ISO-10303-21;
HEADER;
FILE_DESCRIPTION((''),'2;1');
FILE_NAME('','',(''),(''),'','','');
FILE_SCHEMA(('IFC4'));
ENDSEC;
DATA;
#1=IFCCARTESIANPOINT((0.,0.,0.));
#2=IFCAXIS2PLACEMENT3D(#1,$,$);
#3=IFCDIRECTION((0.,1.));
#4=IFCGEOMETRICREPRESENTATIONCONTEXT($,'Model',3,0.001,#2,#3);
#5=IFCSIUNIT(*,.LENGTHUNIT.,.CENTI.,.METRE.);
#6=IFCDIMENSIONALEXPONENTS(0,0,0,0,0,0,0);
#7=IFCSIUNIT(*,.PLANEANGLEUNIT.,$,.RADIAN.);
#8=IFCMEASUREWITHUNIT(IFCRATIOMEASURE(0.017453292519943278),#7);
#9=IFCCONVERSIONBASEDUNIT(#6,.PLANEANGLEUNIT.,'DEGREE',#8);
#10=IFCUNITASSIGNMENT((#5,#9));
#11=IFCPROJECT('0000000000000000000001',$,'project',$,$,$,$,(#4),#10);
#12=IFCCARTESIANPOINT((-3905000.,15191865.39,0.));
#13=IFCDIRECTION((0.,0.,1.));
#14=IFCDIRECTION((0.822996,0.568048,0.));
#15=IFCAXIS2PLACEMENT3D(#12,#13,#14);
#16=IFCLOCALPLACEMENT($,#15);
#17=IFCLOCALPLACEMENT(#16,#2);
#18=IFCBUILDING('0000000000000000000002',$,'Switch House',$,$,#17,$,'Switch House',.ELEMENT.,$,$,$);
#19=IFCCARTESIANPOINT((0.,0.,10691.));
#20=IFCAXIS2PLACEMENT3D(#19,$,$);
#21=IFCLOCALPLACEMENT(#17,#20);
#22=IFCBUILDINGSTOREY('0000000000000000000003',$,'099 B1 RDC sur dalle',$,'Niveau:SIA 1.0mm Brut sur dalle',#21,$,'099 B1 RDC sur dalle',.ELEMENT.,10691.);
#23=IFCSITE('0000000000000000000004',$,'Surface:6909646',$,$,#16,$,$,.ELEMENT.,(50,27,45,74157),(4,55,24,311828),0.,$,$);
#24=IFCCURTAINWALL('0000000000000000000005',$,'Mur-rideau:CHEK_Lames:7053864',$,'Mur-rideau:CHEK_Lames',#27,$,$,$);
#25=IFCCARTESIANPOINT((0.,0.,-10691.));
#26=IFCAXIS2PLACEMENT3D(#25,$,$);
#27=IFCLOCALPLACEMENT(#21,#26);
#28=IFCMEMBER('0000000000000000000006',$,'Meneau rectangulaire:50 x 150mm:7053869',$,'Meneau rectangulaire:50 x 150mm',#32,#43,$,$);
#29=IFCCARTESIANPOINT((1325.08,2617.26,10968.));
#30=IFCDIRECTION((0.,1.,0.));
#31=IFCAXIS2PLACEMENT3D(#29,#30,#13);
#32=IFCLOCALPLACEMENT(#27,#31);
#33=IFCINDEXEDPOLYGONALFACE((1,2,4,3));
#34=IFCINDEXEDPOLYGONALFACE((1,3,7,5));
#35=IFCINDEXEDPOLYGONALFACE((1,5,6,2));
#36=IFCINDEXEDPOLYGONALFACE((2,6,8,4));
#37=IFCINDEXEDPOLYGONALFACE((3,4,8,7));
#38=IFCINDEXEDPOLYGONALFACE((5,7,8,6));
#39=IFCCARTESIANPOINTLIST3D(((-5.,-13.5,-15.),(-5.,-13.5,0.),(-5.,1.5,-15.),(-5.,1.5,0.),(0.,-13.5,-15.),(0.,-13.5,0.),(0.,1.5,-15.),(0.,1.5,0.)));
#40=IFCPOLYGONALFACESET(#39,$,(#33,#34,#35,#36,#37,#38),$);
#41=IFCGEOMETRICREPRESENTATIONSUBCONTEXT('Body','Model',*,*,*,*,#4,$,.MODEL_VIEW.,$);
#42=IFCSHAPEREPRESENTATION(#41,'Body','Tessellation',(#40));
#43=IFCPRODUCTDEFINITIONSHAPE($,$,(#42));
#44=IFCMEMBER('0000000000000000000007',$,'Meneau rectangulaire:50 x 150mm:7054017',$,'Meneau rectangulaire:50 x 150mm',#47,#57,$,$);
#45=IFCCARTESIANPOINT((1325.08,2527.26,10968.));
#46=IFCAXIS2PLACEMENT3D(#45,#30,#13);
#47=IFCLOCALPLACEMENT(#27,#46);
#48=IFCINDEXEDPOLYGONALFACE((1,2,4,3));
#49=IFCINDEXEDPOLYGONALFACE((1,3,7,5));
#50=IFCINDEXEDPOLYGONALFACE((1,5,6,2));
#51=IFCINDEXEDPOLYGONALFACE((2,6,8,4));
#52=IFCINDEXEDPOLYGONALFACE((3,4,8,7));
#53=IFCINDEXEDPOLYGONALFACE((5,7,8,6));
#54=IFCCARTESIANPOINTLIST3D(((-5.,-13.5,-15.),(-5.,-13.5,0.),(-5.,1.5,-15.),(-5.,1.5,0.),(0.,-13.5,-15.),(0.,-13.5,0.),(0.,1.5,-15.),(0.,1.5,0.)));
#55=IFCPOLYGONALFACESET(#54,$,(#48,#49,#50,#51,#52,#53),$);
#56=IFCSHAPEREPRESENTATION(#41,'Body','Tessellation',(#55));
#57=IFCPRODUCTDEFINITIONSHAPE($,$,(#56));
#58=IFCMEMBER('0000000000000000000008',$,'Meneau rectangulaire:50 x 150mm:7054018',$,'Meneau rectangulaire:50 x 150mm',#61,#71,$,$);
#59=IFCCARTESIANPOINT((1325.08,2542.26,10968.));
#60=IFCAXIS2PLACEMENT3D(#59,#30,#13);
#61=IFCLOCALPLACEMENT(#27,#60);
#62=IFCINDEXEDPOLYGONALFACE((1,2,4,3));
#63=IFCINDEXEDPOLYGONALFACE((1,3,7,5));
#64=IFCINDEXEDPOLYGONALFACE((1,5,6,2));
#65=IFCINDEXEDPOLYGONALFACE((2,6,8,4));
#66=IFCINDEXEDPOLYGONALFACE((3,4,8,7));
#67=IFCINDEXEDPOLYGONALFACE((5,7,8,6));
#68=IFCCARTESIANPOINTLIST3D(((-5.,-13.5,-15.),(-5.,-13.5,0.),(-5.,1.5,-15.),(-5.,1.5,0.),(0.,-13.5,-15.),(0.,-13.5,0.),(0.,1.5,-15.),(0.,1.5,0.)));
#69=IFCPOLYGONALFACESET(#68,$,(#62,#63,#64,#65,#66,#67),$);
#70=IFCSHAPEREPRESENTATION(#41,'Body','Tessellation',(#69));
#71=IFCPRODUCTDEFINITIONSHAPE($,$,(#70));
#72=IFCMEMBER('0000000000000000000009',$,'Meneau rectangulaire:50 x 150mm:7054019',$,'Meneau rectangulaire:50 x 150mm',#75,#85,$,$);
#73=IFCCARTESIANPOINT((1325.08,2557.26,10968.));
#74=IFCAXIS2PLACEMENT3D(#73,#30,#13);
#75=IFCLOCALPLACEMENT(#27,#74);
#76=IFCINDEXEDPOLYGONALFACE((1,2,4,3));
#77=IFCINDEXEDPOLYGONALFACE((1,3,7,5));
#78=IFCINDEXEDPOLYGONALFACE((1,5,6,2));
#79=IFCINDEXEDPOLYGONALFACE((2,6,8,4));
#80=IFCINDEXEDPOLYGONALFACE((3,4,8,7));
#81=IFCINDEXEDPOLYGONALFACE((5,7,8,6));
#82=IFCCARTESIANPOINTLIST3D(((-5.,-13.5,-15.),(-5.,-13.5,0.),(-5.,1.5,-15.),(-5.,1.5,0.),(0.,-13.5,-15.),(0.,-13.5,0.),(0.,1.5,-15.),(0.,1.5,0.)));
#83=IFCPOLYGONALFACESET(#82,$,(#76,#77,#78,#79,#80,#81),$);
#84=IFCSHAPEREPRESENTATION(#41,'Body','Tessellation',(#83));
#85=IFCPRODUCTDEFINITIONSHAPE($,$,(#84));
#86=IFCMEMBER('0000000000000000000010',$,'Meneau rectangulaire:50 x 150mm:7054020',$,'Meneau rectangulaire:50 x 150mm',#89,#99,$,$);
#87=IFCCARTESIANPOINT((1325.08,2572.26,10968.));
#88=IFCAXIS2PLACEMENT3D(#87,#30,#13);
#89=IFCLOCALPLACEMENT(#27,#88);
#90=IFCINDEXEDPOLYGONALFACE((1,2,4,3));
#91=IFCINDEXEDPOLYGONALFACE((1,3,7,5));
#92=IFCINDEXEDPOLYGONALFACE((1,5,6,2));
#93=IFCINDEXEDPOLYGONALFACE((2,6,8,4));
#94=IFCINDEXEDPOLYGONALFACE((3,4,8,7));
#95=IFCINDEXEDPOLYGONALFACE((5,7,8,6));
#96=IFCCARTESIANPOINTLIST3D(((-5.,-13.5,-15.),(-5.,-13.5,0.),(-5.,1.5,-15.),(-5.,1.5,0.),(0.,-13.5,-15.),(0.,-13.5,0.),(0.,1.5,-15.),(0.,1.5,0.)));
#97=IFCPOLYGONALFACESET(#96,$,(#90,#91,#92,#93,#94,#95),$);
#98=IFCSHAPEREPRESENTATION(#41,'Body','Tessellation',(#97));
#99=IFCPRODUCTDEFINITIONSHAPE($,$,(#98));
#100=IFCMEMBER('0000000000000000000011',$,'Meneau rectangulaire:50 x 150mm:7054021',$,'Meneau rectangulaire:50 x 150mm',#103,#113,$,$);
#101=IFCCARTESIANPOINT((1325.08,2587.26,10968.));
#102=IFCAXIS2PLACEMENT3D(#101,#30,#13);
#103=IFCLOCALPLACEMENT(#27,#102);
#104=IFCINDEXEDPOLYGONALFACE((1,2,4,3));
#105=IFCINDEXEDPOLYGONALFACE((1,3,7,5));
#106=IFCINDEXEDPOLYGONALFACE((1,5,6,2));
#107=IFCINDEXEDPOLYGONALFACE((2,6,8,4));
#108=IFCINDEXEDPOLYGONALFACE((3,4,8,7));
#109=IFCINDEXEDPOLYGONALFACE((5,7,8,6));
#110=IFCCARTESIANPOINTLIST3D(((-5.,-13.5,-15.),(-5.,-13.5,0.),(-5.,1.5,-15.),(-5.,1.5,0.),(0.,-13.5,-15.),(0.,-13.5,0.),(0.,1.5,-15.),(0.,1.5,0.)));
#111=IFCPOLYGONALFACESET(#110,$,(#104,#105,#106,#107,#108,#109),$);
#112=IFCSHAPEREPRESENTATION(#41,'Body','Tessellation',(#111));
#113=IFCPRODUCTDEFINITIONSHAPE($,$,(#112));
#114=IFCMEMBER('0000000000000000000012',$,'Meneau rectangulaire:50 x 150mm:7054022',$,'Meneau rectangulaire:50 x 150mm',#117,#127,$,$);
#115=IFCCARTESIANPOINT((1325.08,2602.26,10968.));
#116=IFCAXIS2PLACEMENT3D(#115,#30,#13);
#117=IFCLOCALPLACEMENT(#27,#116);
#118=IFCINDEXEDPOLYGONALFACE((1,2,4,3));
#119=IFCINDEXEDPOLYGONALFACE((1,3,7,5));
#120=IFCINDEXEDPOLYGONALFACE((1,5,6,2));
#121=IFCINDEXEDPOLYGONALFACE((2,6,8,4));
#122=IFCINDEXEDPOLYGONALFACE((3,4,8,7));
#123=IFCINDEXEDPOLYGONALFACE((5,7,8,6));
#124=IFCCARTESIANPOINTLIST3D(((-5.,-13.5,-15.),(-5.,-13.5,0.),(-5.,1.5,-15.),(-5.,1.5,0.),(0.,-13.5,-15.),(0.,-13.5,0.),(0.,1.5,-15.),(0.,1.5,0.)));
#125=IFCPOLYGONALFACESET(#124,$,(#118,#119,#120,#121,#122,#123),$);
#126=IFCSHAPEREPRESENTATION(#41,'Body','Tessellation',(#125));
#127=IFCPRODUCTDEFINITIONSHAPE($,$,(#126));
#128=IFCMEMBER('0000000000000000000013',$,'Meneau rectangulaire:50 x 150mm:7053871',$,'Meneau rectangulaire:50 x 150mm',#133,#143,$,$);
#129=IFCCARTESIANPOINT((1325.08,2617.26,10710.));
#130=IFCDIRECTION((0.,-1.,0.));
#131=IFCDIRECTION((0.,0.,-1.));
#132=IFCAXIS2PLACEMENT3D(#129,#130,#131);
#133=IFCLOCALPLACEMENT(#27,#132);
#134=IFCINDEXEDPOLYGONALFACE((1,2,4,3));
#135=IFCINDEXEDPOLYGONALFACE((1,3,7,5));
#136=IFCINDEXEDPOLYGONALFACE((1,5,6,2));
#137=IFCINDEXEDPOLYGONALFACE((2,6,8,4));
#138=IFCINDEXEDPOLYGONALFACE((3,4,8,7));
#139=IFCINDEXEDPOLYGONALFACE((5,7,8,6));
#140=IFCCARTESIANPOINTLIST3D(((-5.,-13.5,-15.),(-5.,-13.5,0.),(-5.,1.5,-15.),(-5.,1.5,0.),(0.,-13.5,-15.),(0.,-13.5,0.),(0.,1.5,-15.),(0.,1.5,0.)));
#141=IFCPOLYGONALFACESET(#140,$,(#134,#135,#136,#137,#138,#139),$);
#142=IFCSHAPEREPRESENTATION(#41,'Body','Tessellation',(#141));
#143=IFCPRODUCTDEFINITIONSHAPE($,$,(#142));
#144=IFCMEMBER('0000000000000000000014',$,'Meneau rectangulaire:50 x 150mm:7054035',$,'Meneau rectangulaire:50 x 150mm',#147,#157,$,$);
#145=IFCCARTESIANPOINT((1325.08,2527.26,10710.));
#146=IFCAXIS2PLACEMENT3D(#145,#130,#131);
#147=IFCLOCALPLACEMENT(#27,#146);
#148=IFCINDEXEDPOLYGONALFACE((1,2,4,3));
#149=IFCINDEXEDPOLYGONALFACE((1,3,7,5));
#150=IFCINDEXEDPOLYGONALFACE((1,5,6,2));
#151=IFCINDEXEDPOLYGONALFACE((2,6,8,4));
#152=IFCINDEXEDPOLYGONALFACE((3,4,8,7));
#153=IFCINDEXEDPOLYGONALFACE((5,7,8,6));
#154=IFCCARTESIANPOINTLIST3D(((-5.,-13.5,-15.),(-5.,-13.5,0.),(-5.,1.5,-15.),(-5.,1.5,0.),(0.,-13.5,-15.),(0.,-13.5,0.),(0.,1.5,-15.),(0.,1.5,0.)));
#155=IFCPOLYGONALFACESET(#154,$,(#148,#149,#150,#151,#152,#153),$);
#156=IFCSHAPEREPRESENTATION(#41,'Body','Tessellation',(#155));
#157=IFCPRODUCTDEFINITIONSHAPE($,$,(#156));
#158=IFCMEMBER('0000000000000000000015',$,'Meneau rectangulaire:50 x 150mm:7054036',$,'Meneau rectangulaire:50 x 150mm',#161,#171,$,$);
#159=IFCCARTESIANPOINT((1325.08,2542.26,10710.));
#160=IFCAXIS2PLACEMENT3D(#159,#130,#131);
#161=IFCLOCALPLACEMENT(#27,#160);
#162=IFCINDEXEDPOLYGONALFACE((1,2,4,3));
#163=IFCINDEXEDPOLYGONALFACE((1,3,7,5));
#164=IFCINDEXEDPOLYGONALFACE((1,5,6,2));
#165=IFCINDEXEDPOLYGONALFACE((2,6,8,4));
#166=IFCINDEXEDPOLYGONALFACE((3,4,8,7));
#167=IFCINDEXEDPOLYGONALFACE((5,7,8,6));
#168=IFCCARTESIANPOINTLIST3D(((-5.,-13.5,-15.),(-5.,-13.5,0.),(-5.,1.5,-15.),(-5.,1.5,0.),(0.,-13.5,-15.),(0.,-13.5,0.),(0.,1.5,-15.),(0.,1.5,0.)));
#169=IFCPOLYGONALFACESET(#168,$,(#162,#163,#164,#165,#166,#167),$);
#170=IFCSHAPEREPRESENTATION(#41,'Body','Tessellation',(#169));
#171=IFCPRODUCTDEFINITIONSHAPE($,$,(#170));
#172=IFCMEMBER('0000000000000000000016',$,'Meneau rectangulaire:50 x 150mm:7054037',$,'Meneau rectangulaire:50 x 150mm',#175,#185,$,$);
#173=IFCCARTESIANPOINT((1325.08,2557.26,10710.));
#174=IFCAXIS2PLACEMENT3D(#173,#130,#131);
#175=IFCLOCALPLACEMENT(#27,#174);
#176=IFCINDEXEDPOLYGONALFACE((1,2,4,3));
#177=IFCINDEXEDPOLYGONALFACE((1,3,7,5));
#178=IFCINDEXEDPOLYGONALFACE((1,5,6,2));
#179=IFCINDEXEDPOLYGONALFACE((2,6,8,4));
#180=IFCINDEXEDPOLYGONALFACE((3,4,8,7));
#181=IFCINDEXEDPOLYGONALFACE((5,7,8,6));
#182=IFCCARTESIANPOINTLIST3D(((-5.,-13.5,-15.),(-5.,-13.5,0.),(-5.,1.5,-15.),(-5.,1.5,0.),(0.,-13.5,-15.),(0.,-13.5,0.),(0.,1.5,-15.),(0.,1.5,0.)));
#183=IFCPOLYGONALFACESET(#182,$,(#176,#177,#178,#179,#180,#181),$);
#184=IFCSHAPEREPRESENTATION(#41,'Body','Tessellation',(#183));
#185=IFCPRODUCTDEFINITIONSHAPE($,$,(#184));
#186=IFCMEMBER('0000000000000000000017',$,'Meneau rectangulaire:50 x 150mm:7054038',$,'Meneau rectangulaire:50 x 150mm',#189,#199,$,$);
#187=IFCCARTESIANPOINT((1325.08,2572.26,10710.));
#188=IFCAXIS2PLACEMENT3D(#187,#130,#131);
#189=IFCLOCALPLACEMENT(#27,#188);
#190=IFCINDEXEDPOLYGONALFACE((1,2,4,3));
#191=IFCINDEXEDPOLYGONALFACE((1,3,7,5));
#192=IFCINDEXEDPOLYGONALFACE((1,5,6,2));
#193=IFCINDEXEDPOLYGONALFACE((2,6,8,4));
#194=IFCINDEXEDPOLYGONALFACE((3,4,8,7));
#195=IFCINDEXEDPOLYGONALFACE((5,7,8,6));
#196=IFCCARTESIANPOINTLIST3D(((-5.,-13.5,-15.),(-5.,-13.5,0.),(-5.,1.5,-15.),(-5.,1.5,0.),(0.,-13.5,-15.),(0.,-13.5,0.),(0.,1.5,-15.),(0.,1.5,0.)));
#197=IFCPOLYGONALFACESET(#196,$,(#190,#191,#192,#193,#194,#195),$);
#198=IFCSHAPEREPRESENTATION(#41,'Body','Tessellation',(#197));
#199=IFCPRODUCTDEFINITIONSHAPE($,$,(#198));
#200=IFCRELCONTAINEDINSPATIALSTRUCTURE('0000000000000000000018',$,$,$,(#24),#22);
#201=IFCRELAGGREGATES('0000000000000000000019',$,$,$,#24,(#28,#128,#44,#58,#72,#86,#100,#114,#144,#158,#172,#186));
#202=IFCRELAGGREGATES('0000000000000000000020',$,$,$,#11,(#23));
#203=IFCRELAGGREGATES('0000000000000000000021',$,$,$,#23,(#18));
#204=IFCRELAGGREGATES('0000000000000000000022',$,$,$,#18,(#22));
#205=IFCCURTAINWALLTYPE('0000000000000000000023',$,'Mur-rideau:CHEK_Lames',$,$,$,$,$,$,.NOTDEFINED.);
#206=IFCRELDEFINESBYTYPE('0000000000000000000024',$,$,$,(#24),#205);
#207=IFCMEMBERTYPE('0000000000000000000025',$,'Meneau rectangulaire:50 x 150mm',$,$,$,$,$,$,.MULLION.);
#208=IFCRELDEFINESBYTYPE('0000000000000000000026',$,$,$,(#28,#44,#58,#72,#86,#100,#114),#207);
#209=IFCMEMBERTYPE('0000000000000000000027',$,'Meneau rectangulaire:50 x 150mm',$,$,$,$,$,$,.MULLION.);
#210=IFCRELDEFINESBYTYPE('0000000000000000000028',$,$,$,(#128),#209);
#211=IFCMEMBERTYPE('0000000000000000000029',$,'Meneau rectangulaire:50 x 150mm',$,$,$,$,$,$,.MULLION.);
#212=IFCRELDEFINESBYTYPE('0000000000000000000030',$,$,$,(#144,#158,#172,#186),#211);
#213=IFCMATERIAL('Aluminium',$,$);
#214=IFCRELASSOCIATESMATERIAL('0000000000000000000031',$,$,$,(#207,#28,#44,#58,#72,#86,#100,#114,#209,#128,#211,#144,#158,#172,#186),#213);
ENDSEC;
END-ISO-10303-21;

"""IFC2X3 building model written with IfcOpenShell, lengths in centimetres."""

from ifc_helpers import new_model, entity, si_unit, converted_unit, direction, frame, origin, origin_2d_with_axis, place, context, subcontext, project, spatial, rectangle, extrude, source, transform, mapped, material, type_object, type_shapes, element, aggregate, save


model = new_model("IFC2X3")

# Units and contexts
model_context = context("Model", 3, precision=0.001, world=origin(), true_north=direction((0.0, 1.0)))
body_context = subcontext(model_context, "Body", "Model", "MODEL_VIEW")
ifc_project = project(units=[si_unit("LENGTHUNIT", "METRE", prefix="CENTI"), converted_unit("PLANEANGLEUNIT", "DEGREE", entity("IfcRatioMeasure", 0.017453292519943278), si_unit("PLANEANGLEUNIT", "RADIAN"), dimensions=[0, 0, 0, 0, 0, 0, 0])], contexts=[model_context])

# Site, building, storey
site_placement = place(None, frame((-3905000.0, 15191865.39, 0.0), z_axis=(0.0, 0.0, 1.0), x_axis=(0.822996, 0.568048, 0.0)))
site = spatial("IfcSite", under=ifc_project, at=site_placement, Name="Surface:6909646", CompositionType="ELEMENT", RefLatitude=(50, 27, 45, 74157), RefLongitude=(4, 55, 24, 311828), RefElevation=0.0)
building_placement = place(site_placement, origin())
building = spatial("IfcBuilding", under=site, at=building_placement, Name="Switch House", LongName="Switch House", CompositionType="ELEMENT")
storey_placement = place(building_placement, frame((0.0, 0.0, 10691.0)))
storey = spatial("IfcBuildingStorey", under=building, at=storey_placement, Name="099 B1 RDC sur dalle", ObjectType="Niveau:SIA 1.0mm Brut sur dalle", LongName="099 B1 RDC sur dalle", CompositionType="ELEMENT", Elevation=10691.0)

# Curtain wall
curtain_wall_type_1 = type_object("IfcCurtainWallType", Name="Mur-rideau:CHEK_Lames", PredefinedType="NOTDEFINED")
curtain_wall_1_placement = place(storey_placement, frame((0.0, 0.0, -10691.0)))
curtain_wall_1 = element("IfcCurtainWall", 1, at=curtain_wall_1_placement, inside=storey, type_object=curtain_wall_type_1, Name="Mur-rideau:CHEK_Lames:7053864", ObjectType="Mur-rideau:CHEK_Lames")
ifc_material_1 = material(Name="Aluminium")

# Members
member_type_1 = type_object("IfcMemberType", Name="Meneau rectangulaire:50 x 150mm", PredefinedType="MULLION", material=ifc_material_1)
shared_shape_1 = source(origin(), body_context, "Body", "SweptSolid", [
    extrude(rectangle(XDim=15.0, YDim=5.0, at=origin_2d_with_axis()), frame((-2.5, -6.0, -15.0), z_axis=(0.0, 0.0, 1.0), x_axis=(0.0, -1.0, 0.0)), (0.0, 0.0, 1.0), 15.0),
])
type_shapes(member_type_1, [shared_shape_1])
member_1_placement = place(curtain_wall_1_placement, frame((1325.08, 2617.26, 10968.0), z_axis=(0.0, 1.0, 0.0), x_axis=(0.0, 0.0, 1.0)))
member_1 = element("IfcMember", 2, at=member_1_placement, type_object=member_type_1, material=ifc_material_1, Name="Meneau rectangulaire:50 x 150mm:7053869", ObjectType="Meneau rectangulaire:50 x 150mm", context=body_context, shape_type="MappedRepresentation", body=[
    mapped(shared_shape_1, transform((0.0, 0.0, 0.0), scale=1.0)),
])
member_2_placement = place(curtain_wall_1_placement, frame((1325.08, 2527.26, 10968.0), z_axis=(0.0, 1.0, 0.0), x_axis=(0.0, 0.0, 1.0)))
member_2 = element("IfcMember", 3, at=member_2_placement, type_object=member_type_1, material=ifc_material_1, Name="Meneau rectangulaire:50 x 150mm:7054017", ObjectType="Meneau rectangulaire:50 x 150mm", context=body_context, shape_type="MappedRepresentation", body=[
    mapped(shared_shape_1, transform((0.0, 0.0, 0.0), scale=1.0)),
])
member_3_placement = place(curtain_wall_1_placement, frame((1325.08, 2542.26, 10968.0), z_axis=(0.0, 1.0, 0.0), x_axis=(0.0, 0.0, 1.0)))
member_3 = element("IfcMember", 4, at=member_3_placement, type_object=member_type_1, material=ifc_material_1, Name="Meneau rectangulaire:50 x 150mm:7054018", ObjectType="Meneau rectangulaire:50 x 150mm", context=body_context, shape_type="MappedRepresentation", body=[
    mapped(shared_shape_1, transform((0.0, 0.0, 0.0), scale=1.0)),
])
member_4_placement = place(curtain_wall_1_placement, frame((1325.08, 2557.26, 10968.0), z_axis=(0.0, 1.0, 0.0), x_axis=(0.0, 0.0, 1.0)))
member_4 = element("IfcMember", 5, at=member_4_placement, type_object=member_type_1, material=ifc_material_1, Name="Meneau rectangulaire:50 x 150mm:7054019", ObjectType="Meneau rectangulaire:50 x 150mm", context=body_context, shape_type="MappedRepresentation", body=[
    mapped(shared_shape_1, transform((0.0, 0.0, 0.0), scale=1.0)),
])
member_5_placement = place(curtain_wall_1_placement, frame((1325.08, 2572.26, 10968.0), z_axis=(0.0, 1.0, 0.0), x_axis=(0.0, 0.0, 1.0)))
member_5 = element("IfcMember", 6, at=member_5_placement, type_object=member_type_1, material=ifc_material_1, Name="Meneau rectangulaire:50 x 150mm:7054020", ObjectType="Meneau rectangulaire:50 x 150mm", context=body_context, shape_type="MappedRepresentation", body=[
    mapped(shared_shape_1, transform((0.0, 0.0, 0.0), scale=1.0)),
])
member_6_placement = place(curtain_wall_1_placement, frame((1325.08, 2587.26, 10968.0), z_axis=(0.0, 1.0, 0.0), x_axis=(0.0, 0.0, 1.0)))
member_6 = element("IfcMember", 7, at=member_6_placement, type_object=member_type_1, material=ifc_material_1, Name="Meneau rectangulaire:50 x 150mm:7054021", ObjectType="Meneau rectangulaire:50 x 150mm", context=body_context, shape_type="MappedRepresentation", body=[
    mapped(shared_shape_1, transform((0.0, 0.0, 0.0), scale=1.0)),
])
member_7_placement = place(curtain_wall_1_placement, frame((1325.08, 2602.26, 10968.0), z_axis=(0.0, 1.0, 0.0), x_axis=(0.0, 0.0, 1.0)))
member_7 = element("IfcMember", 8, at=member_7_placement, type_object=member_type_1, material=ifc_material_1, Name="Meneau rectangulaire:50 x 150mm:7054022", ObjectType="Meneau rectangulaire:50 x 150mm", context=body_context, shape_type="MappedRepresentation", body=[
    mapped(shared_shape_1, transform((0.0, 0.0, 0.0), scale=1.0)),
])
member_type_2 = type_object("IfcMemberType", Name="Meneau rectangulaire:50 x 150mm", PredefinedType="MULLION", material=ifc_material_1)
shared_shape_2 = source(origin(), body_context, "Body", "SweptSolid", [
    extrude(rectangle(XDim=15.0, YDim=5.0, at=origin_2d_with_axis()), frame((-2.5, -6.0, -15.0), z_axis=(0.0, 0.0, 1.0), x_axis=(0.0, -1.0, 0.0)), (0.0, 0.0, 1.0), 15.0),
])
type_shapes(member_type_2, [shared_shape_2])
member_8_placement = place(curtain_wall_1_placement, frame((1325.08, 2617.26, 10710.0), z_axis=(0.0, -1.0, 0.0), x_axis=(0.0, 0.0, -1.0)))
member_8 = element("IfcMember", 9, at=member_8_placement, type_object=member_type_2, material=ifc_material_1, Name="Meneau rectangulaire:50 x 150mm:7053871", ObjectType="Meneau rectangulaire:50 x 150mm", context=body_context, shape_type="MappedRepresentation", body=[
    mapped(shared_shape_2, transform((0.0, 0.0, 0.0), scale=1.0)),
])
member_type_3 = type_object("IfcMemberType", Name="Meneau rectangulaire:50 x 150mm", PredefinedType="MULLION", material=ifc_material_1)
shared_shape_3 = source(origin(), body_context, "Body", "SweptSolid", [
    extrude(rectangle(XDim=15.0, YDim=5.0, at=origin_2d_with_axis()), frame((-2.5, -6.0, -15.0), z_axis=(0.0, 0.0, 1.0), x_axis=(0.0, -1.0, 0.0)), (0.0, 0.0, 1.0), 15.0),
])
type_shapes(member_type_3, [shared_shape_3])
member_9_placement = place(curtain_wall_1_placement, frame((1325.08, 2527.26, 10710.0), z_axis=(0.0, -1.0, 0.0), x_axis=(0.0, 0.0, -1.0)))
member_9 = element("IfcMember", 10, at=member_9_placement, type_object=member_type_3, material=ifc_material_1, Name="Meneau rectangulaire:50 x 150mm:7054035", ObjectType="Meneau rectangulaire:50 x 150mm", context=body_context, shape_type="MappedRepresentation", body=[
    mapped(shared_shape_3, transform((0.0, 0.0, 0.0), scale=1.0)),
])
member_10_placement = place(curtain_wall_1_placement, frame((1325.08, 2542.26, 10710.0), z_axis=(0.0, -1.0, 0.0), x_axis=(0.0, 0.0, -1.0)))
member_10 = element("IfcMember", 11, at=member_10_placement, type_object=member_type_3, material=ifc_material_1, Name="Meneau rectangulaire:50 x 150mm:7054036", ObjectType="Meneau rectangulaire:50 x 150mm", context=body_context, shape_type="MappedRepresentation", body=[
    mapped(shared_shape_3, transform((0.0, 0.0, 0.0), scale=1.0)),
])
member_11_placement = place(curtain_wall_1_placement, frame((1325.08, 2557.26, 10710.0), z_axis=(0.0, -1.0, 0.0), x_axis=(0.0, 0.0, -1.0)))
member_11 = element("IfcMember", 12, at=member_11_placement, type_object=member_type_3, material=ifc_material_1, Name="Meneau rectangulaire:50 x 150mm:7054037", ObjectType="Meneau rectangulaire:50 x 150mm", context=body_context, shape_type="MappedRepresentation", body=[
    mapped(shared_shape_3, transform((0.0, 0.0, 0.0), scale=1.0)),
])
member_12_placement = place(curtain_wall_1_placement, frame((1325.08, 2572.26, 10710.0), z_axis=(0.0, -1.0, 0.0), x_axis=(0.0, 0.0, -1.0)))
member_12 = element("IfcMember", 13, at=member_12_placement, type_object=member_type_3, material=ifc_material_1, Name="Meneau rectangulaire:50 x 150mm:7054038", ObjectType="Meneau rectangulaire:50 x 150mm", context=body_context, shape_type="MappedRepresentation", body=[
    mapped(shared_shape_3, transform((0.0, 0.0, 0.0), scale=1.0)),
])
aggregate(curtain_wall_1, [member_1, member_8, member_2, member_3, member_4, member_5, member_6, member_7, member_9, member_10, member_11, member_12])

save(model, "model.ifc")
